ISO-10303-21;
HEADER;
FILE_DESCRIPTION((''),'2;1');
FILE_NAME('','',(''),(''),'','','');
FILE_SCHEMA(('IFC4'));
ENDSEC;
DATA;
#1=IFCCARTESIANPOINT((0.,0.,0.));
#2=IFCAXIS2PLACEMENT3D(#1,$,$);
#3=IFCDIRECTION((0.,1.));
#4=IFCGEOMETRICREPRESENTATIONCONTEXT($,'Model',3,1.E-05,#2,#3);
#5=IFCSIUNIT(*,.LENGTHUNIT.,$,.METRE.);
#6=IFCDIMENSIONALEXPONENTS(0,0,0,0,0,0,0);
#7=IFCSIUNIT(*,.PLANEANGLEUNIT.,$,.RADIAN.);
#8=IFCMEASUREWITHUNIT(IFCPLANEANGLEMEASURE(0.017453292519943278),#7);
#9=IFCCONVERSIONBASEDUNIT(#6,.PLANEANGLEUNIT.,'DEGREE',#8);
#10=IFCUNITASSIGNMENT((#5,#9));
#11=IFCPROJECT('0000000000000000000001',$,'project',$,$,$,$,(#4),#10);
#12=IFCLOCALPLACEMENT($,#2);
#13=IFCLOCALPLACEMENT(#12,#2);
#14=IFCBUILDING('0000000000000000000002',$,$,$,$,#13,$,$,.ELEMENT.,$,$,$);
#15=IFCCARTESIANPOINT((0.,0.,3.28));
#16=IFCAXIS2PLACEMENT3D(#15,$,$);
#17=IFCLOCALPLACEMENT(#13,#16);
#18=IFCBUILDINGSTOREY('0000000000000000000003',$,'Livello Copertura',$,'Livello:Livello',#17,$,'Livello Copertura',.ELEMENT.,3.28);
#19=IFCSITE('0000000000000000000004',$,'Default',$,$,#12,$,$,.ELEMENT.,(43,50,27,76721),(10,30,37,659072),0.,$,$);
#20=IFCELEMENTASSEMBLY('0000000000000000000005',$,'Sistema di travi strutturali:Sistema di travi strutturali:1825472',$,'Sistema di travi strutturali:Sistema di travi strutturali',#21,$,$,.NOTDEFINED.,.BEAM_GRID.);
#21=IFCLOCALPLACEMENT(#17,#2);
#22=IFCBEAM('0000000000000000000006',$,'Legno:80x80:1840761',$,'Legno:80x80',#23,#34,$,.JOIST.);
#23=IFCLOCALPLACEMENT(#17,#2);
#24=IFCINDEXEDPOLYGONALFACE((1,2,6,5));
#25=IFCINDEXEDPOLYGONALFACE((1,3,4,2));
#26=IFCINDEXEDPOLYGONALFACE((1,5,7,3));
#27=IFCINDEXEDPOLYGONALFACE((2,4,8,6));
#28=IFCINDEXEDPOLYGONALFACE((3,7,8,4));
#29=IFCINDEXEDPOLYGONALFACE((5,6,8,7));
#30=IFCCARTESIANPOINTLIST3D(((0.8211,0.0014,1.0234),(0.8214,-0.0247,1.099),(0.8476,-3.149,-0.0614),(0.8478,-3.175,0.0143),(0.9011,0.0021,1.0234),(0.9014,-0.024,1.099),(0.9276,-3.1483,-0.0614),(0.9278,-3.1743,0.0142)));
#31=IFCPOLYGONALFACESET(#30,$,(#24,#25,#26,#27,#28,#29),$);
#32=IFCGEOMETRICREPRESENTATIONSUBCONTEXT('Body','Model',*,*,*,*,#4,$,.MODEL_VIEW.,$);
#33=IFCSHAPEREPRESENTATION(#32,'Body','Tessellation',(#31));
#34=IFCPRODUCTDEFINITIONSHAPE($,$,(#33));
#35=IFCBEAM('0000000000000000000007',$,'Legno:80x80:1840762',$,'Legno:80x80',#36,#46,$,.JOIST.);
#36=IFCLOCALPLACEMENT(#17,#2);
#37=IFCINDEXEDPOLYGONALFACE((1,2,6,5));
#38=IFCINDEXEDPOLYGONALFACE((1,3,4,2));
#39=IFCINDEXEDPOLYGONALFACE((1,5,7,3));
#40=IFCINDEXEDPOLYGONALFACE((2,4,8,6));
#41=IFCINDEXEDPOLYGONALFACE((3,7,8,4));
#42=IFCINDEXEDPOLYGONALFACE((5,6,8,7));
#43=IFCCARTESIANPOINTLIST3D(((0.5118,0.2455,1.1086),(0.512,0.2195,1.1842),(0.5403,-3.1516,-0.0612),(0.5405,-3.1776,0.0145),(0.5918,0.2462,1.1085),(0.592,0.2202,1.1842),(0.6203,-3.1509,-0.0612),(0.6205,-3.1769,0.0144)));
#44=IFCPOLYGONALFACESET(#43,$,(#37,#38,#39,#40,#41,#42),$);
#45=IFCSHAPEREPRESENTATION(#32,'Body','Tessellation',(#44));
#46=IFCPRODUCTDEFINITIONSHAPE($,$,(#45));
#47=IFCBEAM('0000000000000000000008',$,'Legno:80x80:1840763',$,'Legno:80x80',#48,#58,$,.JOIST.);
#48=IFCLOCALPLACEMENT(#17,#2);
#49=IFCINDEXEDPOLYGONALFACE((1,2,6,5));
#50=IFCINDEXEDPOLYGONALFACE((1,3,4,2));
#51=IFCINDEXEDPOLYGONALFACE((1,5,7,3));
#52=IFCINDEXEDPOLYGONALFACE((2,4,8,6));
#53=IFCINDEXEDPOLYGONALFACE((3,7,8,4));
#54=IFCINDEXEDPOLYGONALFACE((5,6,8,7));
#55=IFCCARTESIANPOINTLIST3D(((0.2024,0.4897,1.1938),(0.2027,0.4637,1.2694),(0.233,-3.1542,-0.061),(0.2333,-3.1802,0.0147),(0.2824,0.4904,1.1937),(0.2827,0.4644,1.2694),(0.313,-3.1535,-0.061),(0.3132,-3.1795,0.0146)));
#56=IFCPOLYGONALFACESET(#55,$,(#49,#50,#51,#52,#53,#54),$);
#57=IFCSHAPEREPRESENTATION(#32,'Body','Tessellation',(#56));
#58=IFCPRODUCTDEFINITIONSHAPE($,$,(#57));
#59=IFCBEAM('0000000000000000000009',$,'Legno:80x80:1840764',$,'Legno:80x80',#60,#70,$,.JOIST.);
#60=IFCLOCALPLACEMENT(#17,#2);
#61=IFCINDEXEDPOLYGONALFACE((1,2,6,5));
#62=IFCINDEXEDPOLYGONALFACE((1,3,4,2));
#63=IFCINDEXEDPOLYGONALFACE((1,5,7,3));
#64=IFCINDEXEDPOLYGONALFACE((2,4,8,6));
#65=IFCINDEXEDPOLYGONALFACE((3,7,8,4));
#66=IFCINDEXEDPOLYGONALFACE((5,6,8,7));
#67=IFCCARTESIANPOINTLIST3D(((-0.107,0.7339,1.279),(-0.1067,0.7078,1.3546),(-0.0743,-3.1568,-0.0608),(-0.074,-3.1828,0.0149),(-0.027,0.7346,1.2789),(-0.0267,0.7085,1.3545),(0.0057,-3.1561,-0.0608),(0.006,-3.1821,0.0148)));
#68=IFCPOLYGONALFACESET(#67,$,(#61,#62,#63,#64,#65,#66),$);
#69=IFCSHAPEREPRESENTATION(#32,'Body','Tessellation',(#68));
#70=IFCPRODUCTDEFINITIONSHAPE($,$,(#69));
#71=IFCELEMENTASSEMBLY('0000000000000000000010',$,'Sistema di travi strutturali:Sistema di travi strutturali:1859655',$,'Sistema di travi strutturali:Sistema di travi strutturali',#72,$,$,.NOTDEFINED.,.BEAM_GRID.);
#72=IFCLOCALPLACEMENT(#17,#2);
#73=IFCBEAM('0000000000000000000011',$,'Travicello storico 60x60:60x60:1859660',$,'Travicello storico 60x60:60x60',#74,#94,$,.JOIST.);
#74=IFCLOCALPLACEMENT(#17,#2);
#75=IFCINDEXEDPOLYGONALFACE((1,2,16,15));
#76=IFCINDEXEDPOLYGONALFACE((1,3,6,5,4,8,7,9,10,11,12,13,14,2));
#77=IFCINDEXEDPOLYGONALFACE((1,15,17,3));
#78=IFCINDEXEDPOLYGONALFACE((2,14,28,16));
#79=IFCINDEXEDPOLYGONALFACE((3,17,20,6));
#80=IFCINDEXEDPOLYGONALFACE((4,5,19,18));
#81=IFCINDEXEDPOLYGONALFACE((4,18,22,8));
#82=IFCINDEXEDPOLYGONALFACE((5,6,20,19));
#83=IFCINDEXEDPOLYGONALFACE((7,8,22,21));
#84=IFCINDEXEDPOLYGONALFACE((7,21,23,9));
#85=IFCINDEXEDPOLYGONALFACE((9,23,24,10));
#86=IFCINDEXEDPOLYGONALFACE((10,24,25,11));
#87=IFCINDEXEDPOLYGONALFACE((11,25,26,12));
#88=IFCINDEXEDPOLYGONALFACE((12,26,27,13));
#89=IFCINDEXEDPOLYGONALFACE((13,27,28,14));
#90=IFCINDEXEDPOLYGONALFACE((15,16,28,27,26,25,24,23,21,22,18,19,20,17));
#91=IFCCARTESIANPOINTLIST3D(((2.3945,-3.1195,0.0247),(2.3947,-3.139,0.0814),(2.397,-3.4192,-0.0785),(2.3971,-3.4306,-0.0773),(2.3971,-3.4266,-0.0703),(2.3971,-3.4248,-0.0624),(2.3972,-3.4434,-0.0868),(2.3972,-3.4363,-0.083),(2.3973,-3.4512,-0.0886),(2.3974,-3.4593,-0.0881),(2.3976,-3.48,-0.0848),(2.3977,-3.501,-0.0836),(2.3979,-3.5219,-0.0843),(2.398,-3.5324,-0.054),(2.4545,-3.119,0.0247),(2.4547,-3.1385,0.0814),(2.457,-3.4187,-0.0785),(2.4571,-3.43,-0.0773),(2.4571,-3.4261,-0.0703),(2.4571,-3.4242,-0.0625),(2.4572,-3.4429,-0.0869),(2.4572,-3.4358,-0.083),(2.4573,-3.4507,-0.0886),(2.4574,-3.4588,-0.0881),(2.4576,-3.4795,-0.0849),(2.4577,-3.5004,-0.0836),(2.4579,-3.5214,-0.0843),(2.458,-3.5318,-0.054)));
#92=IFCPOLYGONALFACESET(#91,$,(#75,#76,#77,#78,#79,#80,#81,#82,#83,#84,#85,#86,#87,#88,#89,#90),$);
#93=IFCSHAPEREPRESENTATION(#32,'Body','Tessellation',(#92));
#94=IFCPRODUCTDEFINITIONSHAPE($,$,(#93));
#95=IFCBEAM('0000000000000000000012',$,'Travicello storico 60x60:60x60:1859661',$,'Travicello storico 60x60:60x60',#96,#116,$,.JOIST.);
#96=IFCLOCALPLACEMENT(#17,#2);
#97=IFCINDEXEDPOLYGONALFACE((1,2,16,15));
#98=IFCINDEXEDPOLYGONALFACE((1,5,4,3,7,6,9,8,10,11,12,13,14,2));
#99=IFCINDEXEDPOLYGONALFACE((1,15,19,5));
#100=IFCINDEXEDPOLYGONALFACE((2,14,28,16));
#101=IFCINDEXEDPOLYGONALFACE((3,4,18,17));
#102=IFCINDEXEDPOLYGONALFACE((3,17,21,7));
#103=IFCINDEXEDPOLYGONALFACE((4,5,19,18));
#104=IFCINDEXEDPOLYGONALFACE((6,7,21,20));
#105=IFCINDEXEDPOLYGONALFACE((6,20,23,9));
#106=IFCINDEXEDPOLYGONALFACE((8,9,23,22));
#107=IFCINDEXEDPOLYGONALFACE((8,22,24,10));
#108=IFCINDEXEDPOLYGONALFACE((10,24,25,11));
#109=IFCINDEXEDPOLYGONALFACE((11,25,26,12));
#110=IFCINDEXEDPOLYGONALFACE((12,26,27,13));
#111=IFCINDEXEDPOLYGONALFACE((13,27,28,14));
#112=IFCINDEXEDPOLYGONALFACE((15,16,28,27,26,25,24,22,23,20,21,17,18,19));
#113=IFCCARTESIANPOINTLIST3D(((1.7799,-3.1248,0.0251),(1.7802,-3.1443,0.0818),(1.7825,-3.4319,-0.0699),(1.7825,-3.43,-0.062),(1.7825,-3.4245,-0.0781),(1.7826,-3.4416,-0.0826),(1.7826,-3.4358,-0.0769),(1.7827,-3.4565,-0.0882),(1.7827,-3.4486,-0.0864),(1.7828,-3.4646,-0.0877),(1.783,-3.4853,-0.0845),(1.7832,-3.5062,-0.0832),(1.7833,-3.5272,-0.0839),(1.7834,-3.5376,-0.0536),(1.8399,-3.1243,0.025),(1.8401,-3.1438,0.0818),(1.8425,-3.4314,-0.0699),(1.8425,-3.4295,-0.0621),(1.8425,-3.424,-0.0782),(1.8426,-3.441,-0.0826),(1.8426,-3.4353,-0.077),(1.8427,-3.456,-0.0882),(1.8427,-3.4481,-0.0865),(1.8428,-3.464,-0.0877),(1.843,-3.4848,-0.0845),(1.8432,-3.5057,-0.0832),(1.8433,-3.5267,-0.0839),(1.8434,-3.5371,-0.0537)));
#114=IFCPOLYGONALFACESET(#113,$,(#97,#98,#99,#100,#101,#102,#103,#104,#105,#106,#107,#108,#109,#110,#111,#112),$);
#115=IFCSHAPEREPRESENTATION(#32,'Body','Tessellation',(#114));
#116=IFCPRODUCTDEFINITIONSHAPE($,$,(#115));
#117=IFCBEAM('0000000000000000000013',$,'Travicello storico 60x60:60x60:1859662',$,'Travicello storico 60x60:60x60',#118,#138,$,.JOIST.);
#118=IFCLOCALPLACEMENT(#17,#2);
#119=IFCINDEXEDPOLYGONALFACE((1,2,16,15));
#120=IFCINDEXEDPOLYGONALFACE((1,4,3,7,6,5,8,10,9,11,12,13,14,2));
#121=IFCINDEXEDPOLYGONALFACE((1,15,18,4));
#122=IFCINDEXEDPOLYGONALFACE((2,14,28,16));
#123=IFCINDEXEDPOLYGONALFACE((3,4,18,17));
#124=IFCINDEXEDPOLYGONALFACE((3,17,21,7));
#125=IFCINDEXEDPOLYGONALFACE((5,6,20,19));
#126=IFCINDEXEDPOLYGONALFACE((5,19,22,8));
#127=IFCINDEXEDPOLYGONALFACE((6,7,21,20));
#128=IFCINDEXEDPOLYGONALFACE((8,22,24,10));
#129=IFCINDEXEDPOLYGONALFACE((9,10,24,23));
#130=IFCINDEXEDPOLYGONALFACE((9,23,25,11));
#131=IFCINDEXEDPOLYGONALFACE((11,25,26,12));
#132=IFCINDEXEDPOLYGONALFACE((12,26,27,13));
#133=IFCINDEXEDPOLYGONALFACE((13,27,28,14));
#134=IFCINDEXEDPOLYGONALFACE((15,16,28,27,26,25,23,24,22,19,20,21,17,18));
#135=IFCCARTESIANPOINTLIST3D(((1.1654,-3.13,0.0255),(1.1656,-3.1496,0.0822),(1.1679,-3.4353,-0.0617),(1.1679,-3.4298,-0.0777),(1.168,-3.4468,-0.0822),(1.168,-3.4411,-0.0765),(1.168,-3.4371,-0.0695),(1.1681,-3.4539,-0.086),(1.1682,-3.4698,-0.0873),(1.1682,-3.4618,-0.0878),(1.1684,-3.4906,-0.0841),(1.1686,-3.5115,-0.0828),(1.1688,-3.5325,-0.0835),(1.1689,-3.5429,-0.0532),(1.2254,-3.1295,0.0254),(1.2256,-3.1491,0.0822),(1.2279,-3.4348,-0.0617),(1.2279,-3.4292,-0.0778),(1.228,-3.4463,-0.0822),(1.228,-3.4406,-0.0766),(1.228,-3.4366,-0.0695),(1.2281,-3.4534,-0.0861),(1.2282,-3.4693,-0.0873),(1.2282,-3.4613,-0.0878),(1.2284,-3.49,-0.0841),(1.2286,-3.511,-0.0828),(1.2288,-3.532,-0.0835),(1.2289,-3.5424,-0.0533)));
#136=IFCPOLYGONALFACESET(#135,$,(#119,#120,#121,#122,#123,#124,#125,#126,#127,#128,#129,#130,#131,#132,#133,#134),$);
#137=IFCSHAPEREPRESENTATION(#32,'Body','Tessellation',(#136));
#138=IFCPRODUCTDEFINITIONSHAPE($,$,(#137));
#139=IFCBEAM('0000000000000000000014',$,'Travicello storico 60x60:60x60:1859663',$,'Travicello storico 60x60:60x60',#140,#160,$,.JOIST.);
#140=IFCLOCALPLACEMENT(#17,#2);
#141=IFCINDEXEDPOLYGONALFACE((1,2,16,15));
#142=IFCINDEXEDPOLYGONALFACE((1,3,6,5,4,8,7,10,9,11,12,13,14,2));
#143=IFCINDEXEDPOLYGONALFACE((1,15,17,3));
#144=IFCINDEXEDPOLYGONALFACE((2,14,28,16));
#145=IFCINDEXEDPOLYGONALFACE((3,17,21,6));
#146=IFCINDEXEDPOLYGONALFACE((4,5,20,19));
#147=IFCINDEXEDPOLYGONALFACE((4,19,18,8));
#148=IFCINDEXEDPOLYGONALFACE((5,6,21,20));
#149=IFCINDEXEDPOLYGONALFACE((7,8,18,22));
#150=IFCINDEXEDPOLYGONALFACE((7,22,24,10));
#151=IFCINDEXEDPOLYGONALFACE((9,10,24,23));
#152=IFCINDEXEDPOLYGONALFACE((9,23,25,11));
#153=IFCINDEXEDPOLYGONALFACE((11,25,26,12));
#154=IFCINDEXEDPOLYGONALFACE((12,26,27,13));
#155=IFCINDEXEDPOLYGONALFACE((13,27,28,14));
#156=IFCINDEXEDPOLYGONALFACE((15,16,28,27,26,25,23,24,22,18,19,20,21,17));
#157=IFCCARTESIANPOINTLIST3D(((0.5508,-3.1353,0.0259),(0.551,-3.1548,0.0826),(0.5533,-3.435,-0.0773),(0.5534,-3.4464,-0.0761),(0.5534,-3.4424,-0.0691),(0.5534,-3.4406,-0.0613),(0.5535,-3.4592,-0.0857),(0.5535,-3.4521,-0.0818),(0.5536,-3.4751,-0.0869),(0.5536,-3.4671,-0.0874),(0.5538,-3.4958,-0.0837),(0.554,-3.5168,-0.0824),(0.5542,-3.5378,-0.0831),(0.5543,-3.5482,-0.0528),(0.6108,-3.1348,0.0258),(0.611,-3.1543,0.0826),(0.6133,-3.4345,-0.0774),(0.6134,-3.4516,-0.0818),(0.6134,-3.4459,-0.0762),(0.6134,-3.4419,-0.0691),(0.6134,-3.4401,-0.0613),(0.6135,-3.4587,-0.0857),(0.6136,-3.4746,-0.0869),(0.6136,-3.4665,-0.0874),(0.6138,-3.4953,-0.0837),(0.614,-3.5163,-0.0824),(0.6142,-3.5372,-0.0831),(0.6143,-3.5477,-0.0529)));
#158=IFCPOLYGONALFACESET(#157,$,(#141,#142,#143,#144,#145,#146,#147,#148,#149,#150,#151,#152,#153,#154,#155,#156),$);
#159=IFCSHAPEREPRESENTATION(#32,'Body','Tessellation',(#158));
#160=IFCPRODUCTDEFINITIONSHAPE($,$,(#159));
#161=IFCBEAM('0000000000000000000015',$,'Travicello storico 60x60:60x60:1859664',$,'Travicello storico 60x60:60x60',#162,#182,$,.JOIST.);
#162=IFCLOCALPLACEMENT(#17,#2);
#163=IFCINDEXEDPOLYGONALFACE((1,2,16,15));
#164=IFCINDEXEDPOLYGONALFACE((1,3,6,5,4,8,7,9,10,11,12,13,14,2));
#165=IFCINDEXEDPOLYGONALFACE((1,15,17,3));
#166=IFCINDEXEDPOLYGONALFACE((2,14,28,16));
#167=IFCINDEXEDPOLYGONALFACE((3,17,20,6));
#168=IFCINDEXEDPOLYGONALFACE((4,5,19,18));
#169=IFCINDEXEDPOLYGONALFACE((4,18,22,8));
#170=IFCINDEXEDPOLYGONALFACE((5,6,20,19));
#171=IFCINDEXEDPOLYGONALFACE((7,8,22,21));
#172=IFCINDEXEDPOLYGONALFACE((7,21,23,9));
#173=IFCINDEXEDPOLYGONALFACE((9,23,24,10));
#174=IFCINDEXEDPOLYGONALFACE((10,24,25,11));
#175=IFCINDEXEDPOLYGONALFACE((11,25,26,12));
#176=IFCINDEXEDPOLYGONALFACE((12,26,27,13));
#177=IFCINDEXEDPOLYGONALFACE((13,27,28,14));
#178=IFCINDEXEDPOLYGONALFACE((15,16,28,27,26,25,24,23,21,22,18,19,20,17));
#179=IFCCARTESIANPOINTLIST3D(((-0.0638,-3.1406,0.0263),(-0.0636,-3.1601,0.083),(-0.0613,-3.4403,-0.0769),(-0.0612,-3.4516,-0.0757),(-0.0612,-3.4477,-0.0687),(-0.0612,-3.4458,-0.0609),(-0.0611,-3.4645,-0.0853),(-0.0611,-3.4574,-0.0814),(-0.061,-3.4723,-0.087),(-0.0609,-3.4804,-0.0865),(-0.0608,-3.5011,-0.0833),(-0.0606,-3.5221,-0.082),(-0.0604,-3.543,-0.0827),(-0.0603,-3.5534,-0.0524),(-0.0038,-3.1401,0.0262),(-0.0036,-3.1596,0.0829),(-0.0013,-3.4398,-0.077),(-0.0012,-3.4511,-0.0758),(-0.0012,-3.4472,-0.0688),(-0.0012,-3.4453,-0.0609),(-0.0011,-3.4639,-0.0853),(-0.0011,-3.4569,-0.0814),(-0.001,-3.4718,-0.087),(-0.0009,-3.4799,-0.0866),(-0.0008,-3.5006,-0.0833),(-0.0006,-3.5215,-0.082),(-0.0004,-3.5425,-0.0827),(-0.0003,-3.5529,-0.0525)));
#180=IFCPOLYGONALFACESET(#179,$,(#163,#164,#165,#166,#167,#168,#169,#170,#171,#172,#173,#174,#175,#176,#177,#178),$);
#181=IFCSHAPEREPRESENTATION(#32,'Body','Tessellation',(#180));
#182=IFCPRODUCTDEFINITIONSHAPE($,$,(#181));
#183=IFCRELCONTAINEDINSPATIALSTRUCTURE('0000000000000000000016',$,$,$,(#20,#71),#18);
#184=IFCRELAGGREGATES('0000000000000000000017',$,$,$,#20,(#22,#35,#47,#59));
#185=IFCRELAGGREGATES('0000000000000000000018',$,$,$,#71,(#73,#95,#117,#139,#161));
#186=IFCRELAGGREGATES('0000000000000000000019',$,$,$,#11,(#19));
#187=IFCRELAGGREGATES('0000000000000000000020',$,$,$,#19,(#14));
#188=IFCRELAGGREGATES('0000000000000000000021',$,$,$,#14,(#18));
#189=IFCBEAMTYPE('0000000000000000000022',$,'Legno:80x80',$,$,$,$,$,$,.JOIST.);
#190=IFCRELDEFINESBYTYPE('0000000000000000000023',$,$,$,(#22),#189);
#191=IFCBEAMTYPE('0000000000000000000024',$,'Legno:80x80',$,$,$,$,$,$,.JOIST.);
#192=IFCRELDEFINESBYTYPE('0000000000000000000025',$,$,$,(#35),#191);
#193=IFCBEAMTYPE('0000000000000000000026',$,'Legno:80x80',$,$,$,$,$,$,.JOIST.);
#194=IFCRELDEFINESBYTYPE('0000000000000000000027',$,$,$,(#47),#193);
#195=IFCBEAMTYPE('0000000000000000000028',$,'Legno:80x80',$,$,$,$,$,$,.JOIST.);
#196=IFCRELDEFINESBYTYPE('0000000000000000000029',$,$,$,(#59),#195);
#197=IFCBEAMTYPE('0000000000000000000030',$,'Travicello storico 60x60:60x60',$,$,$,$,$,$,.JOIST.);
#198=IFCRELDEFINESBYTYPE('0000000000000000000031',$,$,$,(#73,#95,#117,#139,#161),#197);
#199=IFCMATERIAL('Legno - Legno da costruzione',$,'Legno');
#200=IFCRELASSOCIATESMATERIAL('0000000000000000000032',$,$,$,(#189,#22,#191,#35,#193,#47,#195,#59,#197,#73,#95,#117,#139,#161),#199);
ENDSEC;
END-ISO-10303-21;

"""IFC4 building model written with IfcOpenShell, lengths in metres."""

from ifc_helpers import new_model, entity, si_unit, converted_unit, direction, frame, origin, place, context, subcontext, project, spatial, line, arc, indexed_curve, outline, extrude, source, transform, mapped, material, type_object, type_shapes, element, aggregate, save


model = new_model("IFC4")

# Units and contexts
model_context = context("Model", 3, precision=1e-05, world=origin(), true_north=direction((0.0, 1.0)))
body_context = subcontext(model_context, "Body", "Model", "MODEL_VIEW")
ifc_project = project(units=[si_unit("LENGTHUNIT", "METRE"), converted_unit("PLANEANGLEUNIT", "DEGREE", entity("IfcPlaneAngleMeasure", 0.017453292519943278), si_unit("PLANEANGLEUNIT", "RADIAN"), dimensions=[0, 0, 0, 0, 0, 0, 0])], contexts=[model_context])

# Site, building, storey
site_placement = place(None, origin())
site = spatial("IfcSite", under=ifc_project, at=site_placement, Name="Default", CompositionType="ELEMENT", RefLatitude=(43, 50, 27, 76721), RefLongitude=(10, 30, 37, 659072), RefElevation=0.0)
building_placement = place(site_placement, origin())
building = spatial("IfcBuilding", under=site, at=building_placement, CompositionType="ELEMENT")
storey_placement = place(building_placement, frame((0.0, 0.0, 3.28)))
storey = spatial("IfcBuildingStorey", under=building, at=storey_placement, Name="Livello Copertura", ObjectType="Livello:Livello", LongName="Livello Copertura", CompositionType="ELEMENT", Elevation=3.28)

# Shared definitions
ifc_material = material(Name="Legno - Legno da costruzione", Category="Legno")

# Element assemblies, beams
assembly_1_placement = place(storey_placement, origin())
assembly_1 = element("IfcElementAssembly", 1, at=assembly_1_placement, inside=storey, Name="Sistema di travi strutturali:Sistema di travi strutturali:1825472", ObjectType="Sistema di travi strutturali:Sistema di travi strutturali", AssemblyPlace="NOTDEFINED", PredefinedType="BEAM_GRID")
beam_type_1 = type_object("IfcBeamType", Name="Legno:80x80", PredefinedType="JOIST", material=ifc_material)
shared_shape_1 = source(origin(), body_context, "Body", "SweptSolid", [
    extrude(outline(indexed_curve([(-1.666, -0.04), (1.666, -0.04), (1.666, 0.04), (-1.666, 0.04), (-1.666, -0.04)], self_intersect=False)), frame((0.0, 0.0, -0.04), z_axis=(0.0, 0.0, 1.0), x_axis=(-1.0, 0.0, 0.0)), (0.0, 0.0, 1.0), 0.08),
])
type_shapes(beam_type_1, [shared_shape_1])
beam_1_placement = place(assembly_1_placement, frame((0.8745, -1.5865, 0.5188), z_axis=(0.003393, -0.32555, 0.945519), x_axis=(-0.007932, 0.945486, 0.325568)))
beam_1 = element("IfcBeam", 2, at=beam_1_placement, type_object=beam_type_1, material=ifc_material, Name="Legno:80x80:1840761", ObjectType="Legno:80x80", PredefinedType="JOIST", context=body_context, shape_type="MappedRepresentation", body=[
    mapped(shared_shape_1, transform((0.0, 0.0, 0.0), scale=1.0)),
])
beam_type_2 = type_object("IfcBeamType", Name="Legno:80x80", PredefinedType="JOIST", material=ifc_material)
shared_shape_2 = source(origin(), body_context, "Body", "SweptSolid", [
    extrude(outline(indexed_curve([(-1.7965, -0.04), (1.7965, -0.04), (1.7965, 0.04), (-1.7965, 0.04), (-1.7965, -0.04)], self_intersect=False)), frame((0.0, 0.0, -0.04), z_axis=(0.0, 0.0, 1.0), x_axis=(-1.0, 0.0, 0.0)), (0.0, 0.0, 1.0), 0.08),
])
type_shapes(beam_type_2, [shared_shape_2])
beam_2_placement = place(assembly_1_placement, frame((0.5662, -1.4657, 0.5615), z_axis=(0.003393, -0.32555, 0.945519), x_axis=(-0.007932, 0.945486, 0.325568)))
beam_2 = element("IfcBeam", 3, at=beam_2_placement, type_object=beam_type_2, material=ifc_material, Name="Legno:80x80:1840762", ObjectType="Legno:80x80", PredefinedType="JOIST", context=body_context, shape_type="MappedRepresentation", body=[
    mapped(shared_shape_2, transform((0.0, 0.0, 0.0), scale=1.0)),
])
beam_type_3 = type_object("IfcBeamType", Name="Legno:80x80", PredefinedType="JOIST", material=ifc_material)
shared_shape_3 = source(origin(), body_context, "Body", "SweptSolid", [
    extrude(outline(indexed_curve([(-1.927, -0.04), (1.927, -0.04), (1.927, 0.04), (-1.927, 0.04), (-1.927, -0.04)], self_intersect=False)), frame((0.0, 0.0, -0.04), z_axis=(0.0, 0.0, 1.0), x_axis=(-1.0, 0.0, 0.0)), (0.0, 0.0, 1.0), 0.08),
])
type_shapes(beam_type_3, [shared_shape_3])
beam_3_placement = place(assembly_1_placement, frame((0.2578, -1.3449, 0.6042), z_axis=(0.003393, -0.32555, 0.945519), x_axis=(-0.007932, 0.945486, 0.325568)))
beam_3 = element("IfcBeam", 4, at=beam_3_placement, type_object=beam_type_3, material=ifc_material, Name="Legno:80x80:1840763", ObjectType="Legno:80x80", PredefinedType="JOIST", context=body_context, shape_type="MappedRepresentation", body=[
    mapped(shared_shape_3, transform((0.0, 0.0, 0.0), scale=1.0)),
])
beam_type_4 = type_object("IfcBeamType", Name="Legno:80x80", PredefinedType="JOIST", material=ifc_material)
shared_shape_4 = source(origin(), body_context, "Body", "SweptSolid", [
    extrude(outline(indexed_curve([(-2.0575, -0.04), (2.0575, -0.04), (2.0575, 0.04), (-2.0575, 0.04), (-2.0575, -0.04)], self_intersect=False)), frame((0.0, 0.0, -0.04), z_axis=(0.0, 0.0, 1.0), x_axis=(-1.0, 0.0, 0.0)), (0.0, 0.0, 1.0), 0.08),
])
type_shapes(beam_type_4, [shared_shape_4])
beam_4_placement = place(assembly_1_placement, frame((-0.0505, -1.2241, 0.6469), z_axis=(0.003393, -0.32555, 0.945519), x_axis=(-0.007932, 0.945486, 0.325568)))
beam_4 = element("IfcBeam", 5, at=beam_4_placement, type_object=beam_type_4, material=ifc_material, Name="Legno:80x80:1840764", ObjectType="Legno:80x80", PredefinedType="JOIST", context=body_context, shape_type="MappedRepresentation", body=[
    mapped(shared_shape_4, transform((0.0, 0.0, 0.0), scale=1.0)),
])
aggregate(assembly_1, [beam_1, beam_2, beam_3, beam_4])
assembly_2_placement = place(storey_placement, origin())
assembly_2 = element("IfcElementAssembly", 6, at=assembly_2_placement, inside=storey, Name="Sistema di travi strutturali:Sistema di travi strutturali:1859655", ObjectType="Sistema di travi strutturali:Sistema di travi strutturali", AssemblyPlace="NOTDEFINED", PredefinedType="BEAM_GRID")
beam_type_5 = type_object("IfcBeamType", Name="Travicello storico 60x60:60x60", PredefinedType="JOIST", material=ifc_material)
shared_shape_5 = source(origin(), body_context, "Body", "SweptSolid", [
    extrude(outline(indexed_curve([(-0.0359, -0.2606), (0.0241, -0.2606), (0.0241, 0.0564), (0.0071, 0.0564), (0.0228, 0.074), (0.0201, 0.0974), (0.0061, 0.1256), (-0.0039, 0.1554), (-0.0359, 0.1554)], segments=[line(1, 2, 3, 4), arc(4, 5, 6), arc(6, 7, 8), line(8, 9, 1)], self_intersect=False)), frame((0.0874, -0.03, -0.0059), z_axis=(0.0, 1.0, 0.0), x_axis=(0.0, 0.0, -1.0)), (0.0, 0.0, 1.0), 0.06),
])
type_shapes(beam_type_5, [shared_shape_5])
beam_5_placement = place(assembly_2_placement, frame((2.4274, -3.458, -0.0603), z_axis=(0.003393, -0.32555, 0.945519), x_axis=(-0.007932, 0.945486, 0.325568)))
beam_5 = element("IfcBeam", 7, at=beam_5_placement, type_object=beam_type_5, material=ifc_material, Name="Travicello storico 60x60:60x60:1859660", ObjectType="Travicello storico 60x60:60x60", PredefinedType="JOIST", context=body_context, shape_type="MappedRepresentation", body=[
    mapped(shared_shape_5, transform((0.0, 0.0, 0.0), scale=1.0)),
])
beam_6_placement = place(assembly_2_placement, frame((1.8128, -3.4633, -0.0599), z_axis=(0.003393, -0.32555, 0.945519), x_axis=(-0.007932, 0.945486, 0.325568)))
beam_6 = element("IfcBeam", 8, at=beam_6_placement, type_object=beam_type_5, material=ifc_material, Name="Travicello storico 60x60:60x60:1859661", ObjectType="Travicello storico 60x60:60x60", PredefinedType="JOIST", context=body_context, shape_type="MappedRepresentation", body=[
    mapped(shared_shape_5, transform((0.0, 0.0, 0.0), scale=1.0)),
])
beam_7_placement = place(assembly_2_placement, frame((1.1982, -3.4686, -0.0595), z_axis=(0.003393, -0.32555, 0.945519), x_axis=(-0.007932, 0.945486, 0.325568)))
beam_7 = element("IfcBeam", 9, at=beam_7_placement, type_object=beam_type_5, material=ifc_material, Name="Travicello storico 60x60:60x60:1859662", ObjectType="Travicello storico 60x60:60x60", PredefinedType="JOIST", context=body_context, shape_type="MappedRepresentation", body=[
    mapped(shared_shape_5, transform((0.0, 0.0, 0.0), scale=1.0)),
])
beam_8_placement = place(assembly_2_placement, frame((0.5837, -3.4739, -0.0591), z_axis=(0.003393, -0.32555, 0.945519), x_axis=(-0.007932, 0.945486, 0.325568)))
beam_8 = element("IfcBeam", 10, at=beam_8_placement, type_object=beam_type_5, material=ifc_material, Name="Travicello storico 60x60:60x60:1859663", ObjectType="Travicello storico 60x60:60x60", PredefinedType="JOIST", context=body_context, shape_type="MappedRepresentation", body=[
    mapped(shared_shape_5, transform((0.0, 0.0, 0.0), scale=1.0)),
])
beam_9_placement = place(assembly_2_placement, frame((-0.0309, -3.4791, -0.0587), z_axis=(0.003393, -0.32555, 0.945519), x_axis=(-0.007932, 0.945486, 0.325568)))
beam_9 = element("IfcBeam", 11, at=beam_9_placement, type_object=beam_type_5, material=ifc_material, Name="Travicello storico 60x60:60x60:1859664", ObjectType="Travicello storico 60x60:60x60", PredefinedType="JOIST", context=body_context, shape_type="MappedRepresentation", body=[
    mapped(shared_shape_5, transform((0.0, 0.0, 0.0), scale=1.0)),
])
aggregate(assembly_2, [beam_5, beam_6, beam_7, beam_8, beam_9])

save(model, "model.ifc")
